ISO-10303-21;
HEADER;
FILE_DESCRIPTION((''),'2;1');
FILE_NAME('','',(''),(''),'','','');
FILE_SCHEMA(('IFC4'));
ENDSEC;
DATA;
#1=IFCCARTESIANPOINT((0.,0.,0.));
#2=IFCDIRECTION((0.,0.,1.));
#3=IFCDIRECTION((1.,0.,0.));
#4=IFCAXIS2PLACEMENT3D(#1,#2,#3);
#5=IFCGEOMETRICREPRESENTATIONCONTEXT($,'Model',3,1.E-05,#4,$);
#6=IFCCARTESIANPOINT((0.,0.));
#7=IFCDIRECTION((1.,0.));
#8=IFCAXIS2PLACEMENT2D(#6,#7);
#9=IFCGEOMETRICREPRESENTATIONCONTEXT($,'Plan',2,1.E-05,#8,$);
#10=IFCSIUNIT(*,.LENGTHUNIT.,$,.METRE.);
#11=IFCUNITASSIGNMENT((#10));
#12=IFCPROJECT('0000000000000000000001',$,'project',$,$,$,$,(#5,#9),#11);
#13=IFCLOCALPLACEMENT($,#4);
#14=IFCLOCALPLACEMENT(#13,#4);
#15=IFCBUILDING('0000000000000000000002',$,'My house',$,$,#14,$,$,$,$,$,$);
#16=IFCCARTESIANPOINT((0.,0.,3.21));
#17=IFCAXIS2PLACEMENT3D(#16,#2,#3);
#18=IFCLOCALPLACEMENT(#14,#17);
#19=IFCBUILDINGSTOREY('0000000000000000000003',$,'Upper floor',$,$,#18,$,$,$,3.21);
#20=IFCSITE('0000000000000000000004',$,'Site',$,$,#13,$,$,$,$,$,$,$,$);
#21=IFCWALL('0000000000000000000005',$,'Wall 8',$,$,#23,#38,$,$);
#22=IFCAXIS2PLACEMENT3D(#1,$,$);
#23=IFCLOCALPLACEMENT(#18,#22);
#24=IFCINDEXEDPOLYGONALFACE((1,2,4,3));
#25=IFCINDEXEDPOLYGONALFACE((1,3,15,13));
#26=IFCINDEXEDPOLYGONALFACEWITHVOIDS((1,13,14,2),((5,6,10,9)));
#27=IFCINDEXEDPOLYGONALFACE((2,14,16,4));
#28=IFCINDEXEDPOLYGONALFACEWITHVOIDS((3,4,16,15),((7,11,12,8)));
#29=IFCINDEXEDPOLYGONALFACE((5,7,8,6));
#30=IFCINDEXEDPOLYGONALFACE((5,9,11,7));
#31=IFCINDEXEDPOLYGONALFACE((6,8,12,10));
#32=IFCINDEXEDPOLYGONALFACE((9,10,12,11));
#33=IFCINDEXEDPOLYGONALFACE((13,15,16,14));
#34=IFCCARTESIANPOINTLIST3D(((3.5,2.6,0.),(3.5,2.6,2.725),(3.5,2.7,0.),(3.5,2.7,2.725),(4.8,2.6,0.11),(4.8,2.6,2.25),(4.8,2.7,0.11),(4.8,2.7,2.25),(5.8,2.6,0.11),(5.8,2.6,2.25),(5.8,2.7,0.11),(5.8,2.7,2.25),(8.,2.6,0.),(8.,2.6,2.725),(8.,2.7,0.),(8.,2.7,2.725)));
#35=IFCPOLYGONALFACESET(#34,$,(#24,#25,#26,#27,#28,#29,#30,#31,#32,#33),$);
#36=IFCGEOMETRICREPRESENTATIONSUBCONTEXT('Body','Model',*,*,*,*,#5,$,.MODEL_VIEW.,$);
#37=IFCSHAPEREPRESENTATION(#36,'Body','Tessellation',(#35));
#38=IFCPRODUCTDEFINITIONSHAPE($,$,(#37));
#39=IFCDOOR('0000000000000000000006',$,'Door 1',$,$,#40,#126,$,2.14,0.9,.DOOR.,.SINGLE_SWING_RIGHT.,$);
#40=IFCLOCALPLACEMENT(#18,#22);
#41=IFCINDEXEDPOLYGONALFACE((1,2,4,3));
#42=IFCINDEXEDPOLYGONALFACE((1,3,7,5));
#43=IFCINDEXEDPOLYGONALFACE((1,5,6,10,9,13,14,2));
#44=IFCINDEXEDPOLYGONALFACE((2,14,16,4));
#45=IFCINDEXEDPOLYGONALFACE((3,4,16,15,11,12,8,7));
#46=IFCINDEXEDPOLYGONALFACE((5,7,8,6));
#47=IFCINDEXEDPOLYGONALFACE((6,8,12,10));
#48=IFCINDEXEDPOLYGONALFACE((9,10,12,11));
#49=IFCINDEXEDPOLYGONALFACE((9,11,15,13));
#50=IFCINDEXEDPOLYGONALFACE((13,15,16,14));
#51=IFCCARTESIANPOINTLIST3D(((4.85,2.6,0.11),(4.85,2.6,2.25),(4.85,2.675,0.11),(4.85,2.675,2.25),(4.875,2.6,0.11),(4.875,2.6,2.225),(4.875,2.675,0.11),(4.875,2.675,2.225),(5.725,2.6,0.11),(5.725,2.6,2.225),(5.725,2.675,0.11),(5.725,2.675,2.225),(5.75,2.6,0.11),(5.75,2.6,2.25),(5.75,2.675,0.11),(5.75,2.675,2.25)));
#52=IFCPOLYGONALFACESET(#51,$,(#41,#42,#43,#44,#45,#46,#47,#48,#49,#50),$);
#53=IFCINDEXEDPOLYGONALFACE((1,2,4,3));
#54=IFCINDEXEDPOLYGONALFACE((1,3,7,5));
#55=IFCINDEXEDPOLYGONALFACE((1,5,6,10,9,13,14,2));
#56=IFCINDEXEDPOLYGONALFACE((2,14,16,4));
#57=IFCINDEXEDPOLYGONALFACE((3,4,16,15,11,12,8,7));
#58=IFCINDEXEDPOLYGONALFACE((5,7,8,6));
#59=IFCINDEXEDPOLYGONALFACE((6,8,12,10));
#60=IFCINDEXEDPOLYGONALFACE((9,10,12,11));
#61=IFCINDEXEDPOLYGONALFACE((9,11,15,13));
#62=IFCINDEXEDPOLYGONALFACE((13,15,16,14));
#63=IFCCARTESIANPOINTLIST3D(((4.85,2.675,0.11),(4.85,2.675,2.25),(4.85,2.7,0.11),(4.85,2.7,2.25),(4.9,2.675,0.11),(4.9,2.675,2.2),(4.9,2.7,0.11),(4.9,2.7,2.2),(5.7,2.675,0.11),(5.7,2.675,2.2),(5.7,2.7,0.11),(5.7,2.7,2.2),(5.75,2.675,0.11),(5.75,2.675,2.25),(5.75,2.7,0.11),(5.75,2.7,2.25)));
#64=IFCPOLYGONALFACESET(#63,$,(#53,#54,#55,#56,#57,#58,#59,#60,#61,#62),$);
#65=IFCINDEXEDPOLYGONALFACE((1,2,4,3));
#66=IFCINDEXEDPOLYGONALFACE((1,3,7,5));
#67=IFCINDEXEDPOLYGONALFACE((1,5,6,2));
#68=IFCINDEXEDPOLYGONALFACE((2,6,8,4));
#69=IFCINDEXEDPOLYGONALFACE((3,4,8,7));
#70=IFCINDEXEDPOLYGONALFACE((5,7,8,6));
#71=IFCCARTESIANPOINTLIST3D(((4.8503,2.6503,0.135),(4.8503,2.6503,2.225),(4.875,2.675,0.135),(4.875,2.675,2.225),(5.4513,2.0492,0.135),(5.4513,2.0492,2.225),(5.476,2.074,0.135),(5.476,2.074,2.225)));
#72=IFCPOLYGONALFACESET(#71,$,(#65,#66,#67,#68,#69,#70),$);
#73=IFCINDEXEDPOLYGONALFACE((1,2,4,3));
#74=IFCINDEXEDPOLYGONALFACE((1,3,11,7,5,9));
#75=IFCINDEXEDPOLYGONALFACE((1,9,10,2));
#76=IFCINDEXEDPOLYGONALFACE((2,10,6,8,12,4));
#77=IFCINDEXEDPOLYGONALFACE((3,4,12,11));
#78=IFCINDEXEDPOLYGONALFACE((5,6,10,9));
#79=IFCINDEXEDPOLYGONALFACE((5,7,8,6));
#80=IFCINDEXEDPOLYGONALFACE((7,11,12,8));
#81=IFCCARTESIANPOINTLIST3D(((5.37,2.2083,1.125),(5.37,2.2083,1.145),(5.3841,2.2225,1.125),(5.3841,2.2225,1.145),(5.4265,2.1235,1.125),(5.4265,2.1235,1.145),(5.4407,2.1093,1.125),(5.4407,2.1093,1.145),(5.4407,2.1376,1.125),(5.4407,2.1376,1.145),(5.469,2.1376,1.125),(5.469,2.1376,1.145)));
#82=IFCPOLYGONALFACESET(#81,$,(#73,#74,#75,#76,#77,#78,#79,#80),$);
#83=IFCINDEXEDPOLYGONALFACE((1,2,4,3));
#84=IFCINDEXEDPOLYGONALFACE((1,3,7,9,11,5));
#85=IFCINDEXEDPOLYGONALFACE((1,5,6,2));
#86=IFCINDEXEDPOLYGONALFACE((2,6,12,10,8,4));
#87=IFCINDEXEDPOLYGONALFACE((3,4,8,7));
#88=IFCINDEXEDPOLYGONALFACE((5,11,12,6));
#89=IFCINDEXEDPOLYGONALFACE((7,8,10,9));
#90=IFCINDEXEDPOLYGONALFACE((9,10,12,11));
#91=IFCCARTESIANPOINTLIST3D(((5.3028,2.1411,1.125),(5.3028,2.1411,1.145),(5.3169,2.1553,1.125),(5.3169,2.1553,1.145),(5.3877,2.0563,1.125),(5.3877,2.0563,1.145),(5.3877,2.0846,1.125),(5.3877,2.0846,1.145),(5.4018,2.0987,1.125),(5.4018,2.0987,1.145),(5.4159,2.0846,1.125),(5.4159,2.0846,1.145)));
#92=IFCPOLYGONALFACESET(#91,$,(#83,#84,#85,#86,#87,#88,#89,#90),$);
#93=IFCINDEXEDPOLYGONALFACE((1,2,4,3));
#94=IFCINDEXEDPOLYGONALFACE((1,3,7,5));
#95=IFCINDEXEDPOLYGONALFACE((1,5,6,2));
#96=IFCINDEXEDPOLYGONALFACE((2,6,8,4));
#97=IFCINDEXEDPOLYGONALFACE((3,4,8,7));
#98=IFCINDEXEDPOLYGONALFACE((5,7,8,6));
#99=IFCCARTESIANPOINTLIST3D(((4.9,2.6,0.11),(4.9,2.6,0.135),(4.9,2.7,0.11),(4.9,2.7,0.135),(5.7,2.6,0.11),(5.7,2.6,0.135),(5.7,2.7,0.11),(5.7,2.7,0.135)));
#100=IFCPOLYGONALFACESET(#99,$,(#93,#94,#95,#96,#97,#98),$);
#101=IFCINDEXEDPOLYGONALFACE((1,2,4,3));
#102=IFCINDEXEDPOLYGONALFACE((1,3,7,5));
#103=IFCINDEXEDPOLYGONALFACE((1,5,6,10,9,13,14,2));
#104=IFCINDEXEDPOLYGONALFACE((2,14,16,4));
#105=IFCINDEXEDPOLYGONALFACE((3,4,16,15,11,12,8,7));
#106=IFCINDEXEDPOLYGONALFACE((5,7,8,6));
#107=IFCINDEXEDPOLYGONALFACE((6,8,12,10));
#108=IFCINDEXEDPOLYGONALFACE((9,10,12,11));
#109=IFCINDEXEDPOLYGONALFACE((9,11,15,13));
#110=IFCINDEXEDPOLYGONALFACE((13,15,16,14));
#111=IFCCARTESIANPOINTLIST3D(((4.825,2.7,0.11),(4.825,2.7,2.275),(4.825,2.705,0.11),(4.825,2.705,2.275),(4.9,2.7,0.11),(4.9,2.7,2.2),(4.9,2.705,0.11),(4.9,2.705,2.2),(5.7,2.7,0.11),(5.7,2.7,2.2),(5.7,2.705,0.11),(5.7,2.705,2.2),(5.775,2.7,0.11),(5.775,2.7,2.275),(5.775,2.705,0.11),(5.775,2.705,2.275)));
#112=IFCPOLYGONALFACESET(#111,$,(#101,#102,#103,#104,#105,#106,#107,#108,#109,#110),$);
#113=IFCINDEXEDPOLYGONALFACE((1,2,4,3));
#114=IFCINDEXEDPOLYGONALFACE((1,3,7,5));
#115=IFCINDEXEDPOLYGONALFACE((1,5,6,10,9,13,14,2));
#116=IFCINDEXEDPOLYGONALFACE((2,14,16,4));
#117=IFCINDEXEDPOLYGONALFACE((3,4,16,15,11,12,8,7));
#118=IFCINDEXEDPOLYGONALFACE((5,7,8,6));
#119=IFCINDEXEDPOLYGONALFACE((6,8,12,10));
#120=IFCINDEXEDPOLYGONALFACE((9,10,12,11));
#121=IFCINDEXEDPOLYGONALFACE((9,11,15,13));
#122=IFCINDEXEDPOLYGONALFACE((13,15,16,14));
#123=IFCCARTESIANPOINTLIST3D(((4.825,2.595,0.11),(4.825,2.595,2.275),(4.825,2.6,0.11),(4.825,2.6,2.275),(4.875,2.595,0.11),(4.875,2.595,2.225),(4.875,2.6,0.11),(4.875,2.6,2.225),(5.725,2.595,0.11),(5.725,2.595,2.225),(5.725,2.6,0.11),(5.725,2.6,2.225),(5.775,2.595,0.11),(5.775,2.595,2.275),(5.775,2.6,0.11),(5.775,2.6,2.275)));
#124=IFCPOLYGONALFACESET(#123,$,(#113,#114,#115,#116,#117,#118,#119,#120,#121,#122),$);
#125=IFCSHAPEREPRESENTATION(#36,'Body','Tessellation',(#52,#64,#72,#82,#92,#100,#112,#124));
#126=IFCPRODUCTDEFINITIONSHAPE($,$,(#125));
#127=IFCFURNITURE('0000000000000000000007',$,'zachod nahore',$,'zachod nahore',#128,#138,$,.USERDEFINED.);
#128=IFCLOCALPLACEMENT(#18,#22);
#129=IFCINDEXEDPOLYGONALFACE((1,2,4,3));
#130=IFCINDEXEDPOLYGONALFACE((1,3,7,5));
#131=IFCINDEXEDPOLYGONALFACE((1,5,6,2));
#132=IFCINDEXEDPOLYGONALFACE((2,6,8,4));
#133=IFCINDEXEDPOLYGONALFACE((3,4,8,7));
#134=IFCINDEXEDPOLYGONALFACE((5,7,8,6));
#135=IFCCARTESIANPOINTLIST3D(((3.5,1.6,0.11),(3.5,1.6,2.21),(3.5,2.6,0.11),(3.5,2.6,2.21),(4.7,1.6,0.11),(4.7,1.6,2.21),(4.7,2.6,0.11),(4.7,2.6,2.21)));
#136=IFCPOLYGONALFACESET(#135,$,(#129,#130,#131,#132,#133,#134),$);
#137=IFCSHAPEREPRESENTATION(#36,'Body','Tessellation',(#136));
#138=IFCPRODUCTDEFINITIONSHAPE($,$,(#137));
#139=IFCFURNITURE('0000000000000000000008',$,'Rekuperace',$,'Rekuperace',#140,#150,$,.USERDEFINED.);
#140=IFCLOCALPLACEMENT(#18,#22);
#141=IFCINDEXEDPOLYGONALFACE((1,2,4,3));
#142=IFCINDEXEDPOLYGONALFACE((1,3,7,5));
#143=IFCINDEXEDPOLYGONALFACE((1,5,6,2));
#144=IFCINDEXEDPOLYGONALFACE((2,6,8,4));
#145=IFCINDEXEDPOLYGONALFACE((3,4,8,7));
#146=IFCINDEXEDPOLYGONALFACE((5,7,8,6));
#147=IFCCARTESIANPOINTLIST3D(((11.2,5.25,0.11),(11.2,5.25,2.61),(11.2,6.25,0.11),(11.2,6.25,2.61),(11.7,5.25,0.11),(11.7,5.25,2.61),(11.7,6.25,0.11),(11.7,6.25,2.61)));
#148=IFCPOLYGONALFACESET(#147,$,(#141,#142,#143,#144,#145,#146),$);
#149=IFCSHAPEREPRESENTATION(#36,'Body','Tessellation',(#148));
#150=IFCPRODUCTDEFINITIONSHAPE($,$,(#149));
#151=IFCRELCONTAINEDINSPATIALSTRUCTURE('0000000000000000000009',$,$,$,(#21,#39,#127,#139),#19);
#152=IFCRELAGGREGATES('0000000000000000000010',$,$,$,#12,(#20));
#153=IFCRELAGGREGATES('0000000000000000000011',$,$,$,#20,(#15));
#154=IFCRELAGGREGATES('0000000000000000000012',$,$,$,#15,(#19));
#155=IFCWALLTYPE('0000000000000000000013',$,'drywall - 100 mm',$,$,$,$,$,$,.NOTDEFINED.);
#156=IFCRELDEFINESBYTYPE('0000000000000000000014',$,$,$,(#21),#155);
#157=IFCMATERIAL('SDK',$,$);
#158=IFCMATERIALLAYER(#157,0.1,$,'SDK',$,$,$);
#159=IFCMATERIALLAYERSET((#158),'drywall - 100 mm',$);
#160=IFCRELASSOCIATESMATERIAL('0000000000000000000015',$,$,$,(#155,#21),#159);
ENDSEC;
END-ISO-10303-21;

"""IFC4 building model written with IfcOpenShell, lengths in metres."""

from ifc_helpers import new_model, entity, si_unit, frame, origin_with_axes, origin_2d_with_axis, place, context, subcontext, project, spatial, line, indexed_curve, outline, extrude, shape, material, layer, layer_set, layer_usage, type_object, element, fill, save


model = new_model("IFC4")

# Units and contexts
model_context = context("Model", 3, precision=1e-05, world=origin_with_axes())
plan_context = context("Plan", 2, precision=1e-05, world=origin_2d_with_axis())
body_context_1 = subcontext(model_context, "Body", "Model", "MODEL_VIEW")
body_context_2 = subcontext(plan_context, "Body", "Plan", "PLAN_VIEW")
ifc_project = project(units=[si_unit("LENGTHUNIT", "METRE")], contexts=[model_context, plan_context])

# Site, building, storey
site_placement = place(None, origin_with_axes())
site = spatial("IfcSite", under=ifc_project, at=site_placement, Name="Site")
building_placement = place(site_placement, origin_with_axes())
building = spatial("IfcBuilding", under=site, at=building_placement, Name="My house")
storey_placement = place(building_placement, frame((0.0, 0.0, 3.21), z_axis=(0.0, 0.0, 1.0), x_axis=(1.0, 0.0, 0.0)))
storey = spatial("IfcBuildingStorey", under=building, at=storey_placement, Name="Upper floor", Elevation=3.21)

# Wall, opening, door
ifc_material_1 = material(Name="SDK")
ifc_layer_1 = layer(ifc_material_1, 0.1, Name="SDK")
ifc_layer_set_1 = layer_set([ifc_layer_1], Name="drywall - 100 mm")
ifc_layer_usage_1 = layer_usage(ifc_layer_set_1, "AXIS2", "NEGATIVE", 0.1)
wall_type_1 = type_object("IfcWallType", Name="drywall - 100 mm", PredefinedType="NOTDEFINED", material=ifc_layer_set_1)
wall_1_placement = place(storey_placement, frame((8.0, 2.7, 0.0), z_axis=(0.0, 0.0, 1.0), x_axis=(-1.0, 0.0, 0.0)))
wall_1 = element("IfcWall", 1, at=wall_1_placement, inside=storey, type_object=wall_type_1, material=ifc_layer_usage_1, Name="Wall 8", context=body_context_1, shape_type="SweptSolid", body=[
    extrude(outline(indexed_curve([(0.0, 0.0), (0.0, 0.1), (4.5, 0.1), (4.5, 0.0), (0.0, 0.0)], self_intersect=False)), origin_with_axes(), (0.0, 0.0, 1.0), 2.725),
])
opening_1_placement = place(wall_1_placement, frame((2.2, 0.0, 0.11), z_axis=(0.0, 0.0, 1.0), x_axis=(1.0, 0.0, 0.0)))
opening_1 = element("IfcOpeningElement", 2, at=opening_1_placement, cuts=wall_1, PredefinedType="OPENING", context=body_context_1, shape_type="SweptSolid", body=[
    extrude(outline(indexed_curve([(0.0, 0.0), (0.0, 0.2), (1.0, 0.2), (1.0, 0.0), (0.0, 0.0)], self_intersect=False)), frame((0.0, -0.05, 0.0), z_axis=(0.0, 0.0, 1.0), x_axis=(1.0, 0.0, 0.0)), (0.0, 0.0, 1.0), 2.14),
])
door_1_placement = place(opening_1_placement, frame((0.05, 0.0, 0.0), z_axis=(0.0, 0.0, 1.0), x_axis=(1.0, 0.0, 0.0)))
door_1 = element("IfcDoor", 3, at=door_1_placement, inside=storey, Name="Door 1", OperationType="SINGLE_SWING_RIGHT", OverallHeight=2.14, OverallWidth=0.9, PredefinedType="DOOR", shapes=[
    shape(body_context_1, "Body", "SweptSolid", [extrude(outline(indexed_curve([(0.0, 0.0), (0.0, 2.14), (0.9, 2.14), (0.9, 0.0), (0.875, 0.0), (0.875, 2.115), (0.025, 2.115), (0.025, 0.0)], segments=[line(1, 2, 3, 4, 5, 6, 7, 8, 1)])), frame((0.0, 0.025, 0.0), z_axis=(0.0, -1.0, 0.0), x_axis=(1.0, 0.0, 0.0)), (0.0, 0.0, -1.0), 0.075), extrude(outline(indexed_curve([(0.0, 0.0), (0.0, 2.14), (0.9, 2.14), (0.9, 0.0), (0.85, 0.0), (0.85, 2.09), (0.05, 2.09), (0.05, 0.0)], segments=[line(1, 2, 3, 4, 5, 6, 7, 8, 1)])), frame((0.0, 0.0, 0.0), z_axis=(0.0, -1.0, 0.0), x_axis=(1.0, 0.0, 0.0)), (0.0, 0.0, -1.0), 0.025), extrude(outline(indexed_curve([(0.0, 0.0), (0.85, 0.0), (0.85, 0.035), (0.0, 0.035)], segments=[line(1, 2, 3, 4, 1)])), frame((0.274, 0.626, 0.025), z_axis=(0.0, 0.0, 1.0), x_axis=(0.707107, -0.707107, 0.0)), (0.0, 0.0, 1.0), 2.09), extrude(outline(indexed_curve([(0.0, 0.0), (0.0, -0.04), (0.12, -0.04), (0.12, -0.02), (0.02, -0.02), (0.02, 0.0)], segments=[line(1, 2, 3, 4, 5, 6, 1)])), frame((0.3093, 0.5907, 1.015), z_axis=(0.0, 0.0, 1.0), x_axis=(0.707107, -0.707107, 0.0)), (0.0, 0.0, 1.0), 0.02), extrude(outline(indexed_curve([(0.0, 0.0), (0.0, 0.04), (0.12, 0.04), (0.12, 0.02), (0.02, 0.02), (0.02, 0.0)], segments=[line(1, 2, 3, 4, 5, 6, 1)])), frame((0.3341, 0.6154, 1.015), z_axis=(0.0, 0.0, 1.0), x_axis=(0.707107, -0.707107, 0.0)), (0.0, 0.0, 1.0), 0.02), extrude(outline(indexed_curve([(0.0, 0.0), (0.8, 0.0), (0.8, 0.1), (0.0, 0.1)], segments=[line(1, 2, 3, 4, 1)])), frame((0.05, 0.0, 0.0), z_axis=(0.0, 0.0, 1.0), x_axis=(1.0, 0.0, 0.0)), (0.0, 0.0, 1.0), 0.025), extrude(outline(indexed_curve([(0.0, 0.0), (0.0, 2.165), (0.95, 2.165), (0.95, 0.0), (0.875, 0.0), (0.875, 2.09), (0.075, 2.09), (0.075, 0.0)], segments=[line(1, 2, 3, 4, 5, 6, 7, 8, 1)])), frame((-0.025, -0.005, 0.0), z_axis=(0.0, -1.0, 0.0), x_axis=(1.0, 0.0, 0.0)), (0.0, 0.0, -1.0), 0.005), extrude(outline(indexed_curve([(0.0, 0.0), (0.0, 2.165), (0.95, 2.165), (0.95, 0.0), (0.9, 0.0), (0.9, 2.115), (0.05, 2.115), (0.05, 0.0)], segments=[line(1, 2, 3, 4, 5, 6, 7, 8, 1)])), frame((-0.025, 0.1, 0.0), z_axis=(0.0, -1.0, 0.0), x_axis=(1.0, 0.0, 0.0)), (0.0, 0.0, -1.0), 0.005)]),
    shape(body_context_2, "Body", "Curve2D", [entity("IfcIndexedPolyCurve", entity("IfcCartesianPointList2D", [[0.0, 0.0], [0.0, 0.1], [0.025, 0.1], [0.025, 0.025], [0.05, 0.025], [0.05, 0.0]]), [entity("IfcLineIndex", [1, 2, 3, 4, 5, 6, 1])]), entity("IfcIndexedPolyCurve", entity("IfcCartesianPointList2D", [[0.9, 0.0], [0.9, 0.1], [0.875, 0.1], [0.875, 0.025], [0.85, 0.025], [0.85, 0.0]]), [entity("IfcLineIndex", [1, 2, 3, 4, 5, 6, 1])]), entity("IfcTrimmedCurve", entity("IfcEllipse", entity("IfcAxis2Placement2D", entity("IfcCartesianPoint", [0.84, 0.1]), entity("IfcDirection", [1.0, 0.0])), 0.815, 0.85), [entity("IfcCartesianPoint", [0.84, 0.95])], [entity("IfcCartesianPoint", [0.025, 0.1])], True, "CARTESIAN"), entity("IfcIndexedPolyCurve", entity("IfcCartesianPointList2D", [[0.875, 0.1], [0.84, 0.1], [0.84, 0.95], [0.875, 0.95]]), [entity("IfcLineIndex", [1, 2, 3, 4, 1])])]),
])
fill(opening_1, door_1)

# Furniture
furniture_1_placement = place(storey_placement, frame((4.1, 2.1, 0.11), z_axis=(0.0, 0.0, 1.0), x_axis=(1.0, 0.0, 0.0)))
element("IfcFurniture", 4, at=furniture_1_placement, inside=storey, Name="zachod nahore", ObjectType="zachod nahore", PredefinedType="USERDEFINED", shapes=[
    shape(body_context_1, "Body", "SweptSolid", [extrude(outline(indexed_curve([(-0.6, -0.5), (0.6, -0.5), (0.6, 0.5), (-0.6, 0.5)])), None, (0.0, 0.0, 1.0), 2.1)]),
    shape(body_context_2, "Body", "Curve2D", [entity("IfcIndexedPolyCurve", entity("IfcCartesianPointList2D", [[-0.6, -0.5], [0.6, -0.5], [0.6, 0.5], [-0.6, 0.5], [-0.6, -0.5]]), None, False)]),
])
furniture_2_placement = place(storey_placement, frame((11.45, 5.75, 0.11), z_axis=(0.0, 0.0, 1.0), x_axis=(0.0, 1.0, 0.0)))
element("IfcFurniture", 5, at=furniture_2_placement, inside=storey, Name="Rekuperace", ObjectType="Rekuperace", PredefinedType="USERDEFINED", shapes=[
    shape(body_context_1, "Body", "SweptSolid", [extrude(outline(indexed_curve([(-0.5, -0.25), (0.5, -0.25), (0.5, 0.25), (-0.5, 0.25)])), None, (0.0, 0.0, 1.0), 2.5)]),
    shape(body_context_2, "Body", "Curve2D", [entity("IfcIndexedPolyCurve", entity("IfcCartesianPointList2D", [[-0.5, -0.25], [0.5, -0.25], [0.5, 0.25], [-0.5, 0.25], [-0.5, -0.25]]), None, False)]),
])

save(model, "model.ifc")
